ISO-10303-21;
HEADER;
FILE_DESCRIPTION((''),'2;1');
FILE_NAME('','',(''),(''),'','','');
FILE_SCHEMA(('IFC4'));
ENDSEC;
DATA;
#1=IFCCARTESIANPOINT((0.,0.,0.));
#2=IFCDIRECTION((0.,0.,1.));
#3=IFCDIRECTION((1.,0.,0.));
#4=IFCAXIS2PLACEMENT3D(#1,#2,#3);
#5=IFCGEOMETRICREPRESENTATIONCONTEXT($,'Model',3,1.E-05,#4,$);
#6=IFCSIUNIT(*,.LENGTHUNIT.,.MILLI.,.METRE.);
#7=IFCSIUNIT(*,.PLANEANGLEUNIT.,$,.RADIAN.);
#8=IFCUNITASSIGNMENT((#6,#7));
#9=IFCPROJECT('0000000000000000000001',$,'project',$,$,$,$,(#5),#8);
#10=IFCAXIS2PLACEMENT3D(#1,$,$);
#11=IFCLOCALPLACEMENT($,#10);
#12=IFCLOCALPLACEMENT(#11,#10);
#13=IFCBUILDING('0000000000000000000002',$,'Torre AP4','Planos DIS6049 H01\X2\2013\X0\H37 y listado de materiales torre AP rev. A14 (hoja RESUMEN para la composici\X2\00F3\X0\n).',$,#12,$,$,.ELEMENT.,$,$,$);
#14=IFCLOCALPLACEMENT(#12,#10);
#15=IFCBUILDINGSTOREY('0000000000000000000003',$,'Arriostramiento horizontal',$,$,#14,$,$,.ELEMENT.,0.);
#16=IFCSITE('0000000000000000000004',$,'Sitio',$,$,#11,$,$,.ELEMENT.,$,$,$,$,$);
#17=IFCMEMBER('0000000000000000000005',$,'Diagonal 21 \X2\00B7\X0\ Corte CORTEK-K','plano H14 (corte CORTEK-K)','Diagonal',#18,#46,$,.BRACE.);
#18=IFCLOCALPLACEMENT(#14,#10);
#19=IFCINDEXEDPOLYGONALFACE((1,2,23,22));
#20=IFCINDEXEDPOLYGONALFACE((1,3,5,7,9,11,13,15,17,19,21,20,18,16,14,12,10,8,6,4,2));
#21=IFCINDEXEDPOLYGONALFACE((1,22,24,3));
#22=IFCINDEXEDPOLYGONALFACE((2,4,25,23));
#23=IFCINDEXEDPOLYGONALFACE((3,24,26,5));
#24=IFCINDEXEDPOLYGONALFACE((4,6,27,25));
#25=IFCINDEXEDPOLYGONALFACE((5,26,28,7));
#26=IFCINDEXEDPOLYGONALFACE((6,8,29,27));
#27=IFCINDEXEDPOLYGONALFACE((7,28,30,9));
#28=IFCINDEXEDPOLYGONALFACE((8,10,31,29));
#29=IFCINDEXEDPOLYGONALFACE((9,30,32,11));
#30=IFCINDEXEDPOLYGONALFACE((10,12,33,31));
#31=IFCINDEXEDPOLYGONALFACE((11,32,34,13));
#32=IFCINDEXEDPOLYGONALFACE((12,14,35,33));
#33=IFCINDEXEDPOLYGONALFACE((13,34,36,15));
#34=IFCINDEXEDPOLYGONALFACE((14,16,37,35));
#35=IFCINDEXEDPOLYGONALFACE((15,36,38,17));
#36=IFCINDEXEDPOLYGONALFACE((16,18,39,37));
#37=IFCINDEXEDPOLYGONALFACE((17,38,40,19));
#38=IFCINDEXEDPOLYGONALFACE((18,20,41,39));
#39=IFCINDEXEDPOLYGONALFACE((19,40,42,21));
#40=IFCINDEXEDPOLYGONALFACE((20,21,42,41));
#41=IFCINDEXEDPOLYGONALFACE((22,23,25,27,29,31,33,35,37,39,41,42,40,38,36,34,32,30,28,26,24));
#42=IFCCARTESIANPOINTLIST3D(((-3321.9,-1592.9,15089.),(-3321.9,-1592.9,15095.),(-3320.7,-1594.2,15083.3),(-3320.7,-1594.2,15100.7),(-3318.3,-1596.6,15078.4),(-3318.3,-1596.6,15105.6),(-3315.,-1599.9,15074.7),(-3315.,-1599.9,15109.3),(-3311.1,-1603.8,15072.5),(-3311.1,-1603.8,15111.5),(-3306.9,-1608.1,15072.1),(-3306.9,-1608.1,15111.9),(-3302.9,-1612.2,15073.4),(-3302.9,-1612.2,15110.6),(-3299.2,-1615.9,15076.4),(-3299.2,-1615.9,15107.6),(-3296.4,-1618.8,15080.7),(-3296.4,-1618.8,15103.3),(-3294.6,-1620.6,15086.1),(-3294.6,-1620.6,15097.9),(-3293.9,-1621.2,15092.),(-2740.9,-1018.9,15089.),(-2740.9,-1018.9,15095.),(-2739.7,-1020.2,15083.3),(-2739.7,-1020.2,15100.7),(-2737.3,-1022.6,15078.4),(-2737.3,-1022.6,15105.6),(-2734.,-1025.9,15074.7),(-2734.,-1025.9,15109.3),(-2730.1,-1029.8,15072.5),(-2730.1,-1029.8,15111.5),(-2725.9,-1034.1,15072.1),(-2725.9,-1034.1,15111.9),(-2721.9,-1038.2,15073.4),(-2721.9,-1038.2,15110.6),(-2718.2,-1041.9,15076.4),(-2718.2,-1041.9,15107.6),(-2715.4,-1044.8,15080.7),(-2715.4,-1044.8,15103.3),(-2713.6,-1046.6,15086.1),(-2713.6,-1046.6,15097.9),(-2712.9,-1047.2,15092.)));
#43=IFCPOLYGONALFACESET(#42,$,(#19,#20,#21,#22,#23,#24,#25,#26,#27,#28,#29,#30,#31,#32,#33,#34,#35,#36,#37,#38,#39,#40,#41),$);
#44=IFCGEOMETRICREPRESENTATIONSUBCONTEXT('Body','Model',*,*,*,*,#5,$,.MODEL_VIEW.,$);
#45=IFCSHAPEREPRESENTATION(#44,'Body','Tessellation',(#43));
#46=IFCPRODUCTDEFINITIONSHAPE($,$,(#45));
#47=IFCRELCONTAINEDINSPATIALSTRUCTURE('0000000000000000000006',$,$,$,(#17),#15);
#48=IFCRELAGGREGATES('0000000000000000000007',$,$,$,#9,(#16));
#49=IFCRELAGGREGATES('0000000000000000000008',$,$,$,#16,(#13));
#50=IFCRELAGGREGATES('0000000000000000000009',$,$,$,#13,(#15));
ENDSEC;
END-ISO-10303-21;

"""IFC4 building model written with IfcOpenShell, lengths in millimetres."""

from ifc_helpers import new_model, si_unit, frame, origin, origin_with_axes, place, context, subcontext, project, spatial, circle, extrude, element, save


model = new_model("IFC4")

# Units and contexts
model_context = context("Model", 3, precision=1e-05, world=origin_with_axes())
body_context = subcontext(model_context, "Body", "Model", "MODEL_VIEW")
ifc_project = project(units=[si_unit("LENGTHUNIT", "METRE", prefix="MILLI"), si_unit("PLANEANGLEUNIT", "RADIAN")], contexts=[model_context])

# Site, building, storey
site_placement = place(None, origin())
site = spatial("IfcSite", under=ifc_project, at=site_placement, Name="Sitio", CompositionType="ELEMENT")
building_placement = place(site_placement, origin())
building = spatial("IfcBuilding", under=site, at=building_placement, Name="Torre AP4", Description="Planos DIS6049 H01–H37 y listado de materiales torre AP rev. A14 (hoja RESUMEN para la composición).", CompositionType="ELEMENT")
storey_placement = place(building_placement, origin())
storey = spatial("IfcBuildingStorey", under=building, at=storey_placement, Name="Arriostramiento horizontal", CompositionType="ELEMENT", Elevation=0.0)

# Member
for number, where, z_axis, x_axis, name in (
    (1, (-2727.0, -1033.0, 15092.0), (-0.711379, -0.702808, 0.0), (0.702808, -0.711379, 0.0), "Diagonal 21 · Corte CORTEK-K"),
):
    element("IfcMember", number, at=place(storey_placement, frame(where, z_axis=z_axis, x_axis=x_axis)), inside=storey, Name=name, Description="plano H14 (corte CORTEK-K)", ObjectType="Diagonal", PredefinedType="BRACE", context=body_context, shape_type="SweptSolid", body=[
        extrude(circle(Radius=20.0), None, (0.0, 0.0, 1.0), 816.7),
    ])

save(model, "model.ifc")
